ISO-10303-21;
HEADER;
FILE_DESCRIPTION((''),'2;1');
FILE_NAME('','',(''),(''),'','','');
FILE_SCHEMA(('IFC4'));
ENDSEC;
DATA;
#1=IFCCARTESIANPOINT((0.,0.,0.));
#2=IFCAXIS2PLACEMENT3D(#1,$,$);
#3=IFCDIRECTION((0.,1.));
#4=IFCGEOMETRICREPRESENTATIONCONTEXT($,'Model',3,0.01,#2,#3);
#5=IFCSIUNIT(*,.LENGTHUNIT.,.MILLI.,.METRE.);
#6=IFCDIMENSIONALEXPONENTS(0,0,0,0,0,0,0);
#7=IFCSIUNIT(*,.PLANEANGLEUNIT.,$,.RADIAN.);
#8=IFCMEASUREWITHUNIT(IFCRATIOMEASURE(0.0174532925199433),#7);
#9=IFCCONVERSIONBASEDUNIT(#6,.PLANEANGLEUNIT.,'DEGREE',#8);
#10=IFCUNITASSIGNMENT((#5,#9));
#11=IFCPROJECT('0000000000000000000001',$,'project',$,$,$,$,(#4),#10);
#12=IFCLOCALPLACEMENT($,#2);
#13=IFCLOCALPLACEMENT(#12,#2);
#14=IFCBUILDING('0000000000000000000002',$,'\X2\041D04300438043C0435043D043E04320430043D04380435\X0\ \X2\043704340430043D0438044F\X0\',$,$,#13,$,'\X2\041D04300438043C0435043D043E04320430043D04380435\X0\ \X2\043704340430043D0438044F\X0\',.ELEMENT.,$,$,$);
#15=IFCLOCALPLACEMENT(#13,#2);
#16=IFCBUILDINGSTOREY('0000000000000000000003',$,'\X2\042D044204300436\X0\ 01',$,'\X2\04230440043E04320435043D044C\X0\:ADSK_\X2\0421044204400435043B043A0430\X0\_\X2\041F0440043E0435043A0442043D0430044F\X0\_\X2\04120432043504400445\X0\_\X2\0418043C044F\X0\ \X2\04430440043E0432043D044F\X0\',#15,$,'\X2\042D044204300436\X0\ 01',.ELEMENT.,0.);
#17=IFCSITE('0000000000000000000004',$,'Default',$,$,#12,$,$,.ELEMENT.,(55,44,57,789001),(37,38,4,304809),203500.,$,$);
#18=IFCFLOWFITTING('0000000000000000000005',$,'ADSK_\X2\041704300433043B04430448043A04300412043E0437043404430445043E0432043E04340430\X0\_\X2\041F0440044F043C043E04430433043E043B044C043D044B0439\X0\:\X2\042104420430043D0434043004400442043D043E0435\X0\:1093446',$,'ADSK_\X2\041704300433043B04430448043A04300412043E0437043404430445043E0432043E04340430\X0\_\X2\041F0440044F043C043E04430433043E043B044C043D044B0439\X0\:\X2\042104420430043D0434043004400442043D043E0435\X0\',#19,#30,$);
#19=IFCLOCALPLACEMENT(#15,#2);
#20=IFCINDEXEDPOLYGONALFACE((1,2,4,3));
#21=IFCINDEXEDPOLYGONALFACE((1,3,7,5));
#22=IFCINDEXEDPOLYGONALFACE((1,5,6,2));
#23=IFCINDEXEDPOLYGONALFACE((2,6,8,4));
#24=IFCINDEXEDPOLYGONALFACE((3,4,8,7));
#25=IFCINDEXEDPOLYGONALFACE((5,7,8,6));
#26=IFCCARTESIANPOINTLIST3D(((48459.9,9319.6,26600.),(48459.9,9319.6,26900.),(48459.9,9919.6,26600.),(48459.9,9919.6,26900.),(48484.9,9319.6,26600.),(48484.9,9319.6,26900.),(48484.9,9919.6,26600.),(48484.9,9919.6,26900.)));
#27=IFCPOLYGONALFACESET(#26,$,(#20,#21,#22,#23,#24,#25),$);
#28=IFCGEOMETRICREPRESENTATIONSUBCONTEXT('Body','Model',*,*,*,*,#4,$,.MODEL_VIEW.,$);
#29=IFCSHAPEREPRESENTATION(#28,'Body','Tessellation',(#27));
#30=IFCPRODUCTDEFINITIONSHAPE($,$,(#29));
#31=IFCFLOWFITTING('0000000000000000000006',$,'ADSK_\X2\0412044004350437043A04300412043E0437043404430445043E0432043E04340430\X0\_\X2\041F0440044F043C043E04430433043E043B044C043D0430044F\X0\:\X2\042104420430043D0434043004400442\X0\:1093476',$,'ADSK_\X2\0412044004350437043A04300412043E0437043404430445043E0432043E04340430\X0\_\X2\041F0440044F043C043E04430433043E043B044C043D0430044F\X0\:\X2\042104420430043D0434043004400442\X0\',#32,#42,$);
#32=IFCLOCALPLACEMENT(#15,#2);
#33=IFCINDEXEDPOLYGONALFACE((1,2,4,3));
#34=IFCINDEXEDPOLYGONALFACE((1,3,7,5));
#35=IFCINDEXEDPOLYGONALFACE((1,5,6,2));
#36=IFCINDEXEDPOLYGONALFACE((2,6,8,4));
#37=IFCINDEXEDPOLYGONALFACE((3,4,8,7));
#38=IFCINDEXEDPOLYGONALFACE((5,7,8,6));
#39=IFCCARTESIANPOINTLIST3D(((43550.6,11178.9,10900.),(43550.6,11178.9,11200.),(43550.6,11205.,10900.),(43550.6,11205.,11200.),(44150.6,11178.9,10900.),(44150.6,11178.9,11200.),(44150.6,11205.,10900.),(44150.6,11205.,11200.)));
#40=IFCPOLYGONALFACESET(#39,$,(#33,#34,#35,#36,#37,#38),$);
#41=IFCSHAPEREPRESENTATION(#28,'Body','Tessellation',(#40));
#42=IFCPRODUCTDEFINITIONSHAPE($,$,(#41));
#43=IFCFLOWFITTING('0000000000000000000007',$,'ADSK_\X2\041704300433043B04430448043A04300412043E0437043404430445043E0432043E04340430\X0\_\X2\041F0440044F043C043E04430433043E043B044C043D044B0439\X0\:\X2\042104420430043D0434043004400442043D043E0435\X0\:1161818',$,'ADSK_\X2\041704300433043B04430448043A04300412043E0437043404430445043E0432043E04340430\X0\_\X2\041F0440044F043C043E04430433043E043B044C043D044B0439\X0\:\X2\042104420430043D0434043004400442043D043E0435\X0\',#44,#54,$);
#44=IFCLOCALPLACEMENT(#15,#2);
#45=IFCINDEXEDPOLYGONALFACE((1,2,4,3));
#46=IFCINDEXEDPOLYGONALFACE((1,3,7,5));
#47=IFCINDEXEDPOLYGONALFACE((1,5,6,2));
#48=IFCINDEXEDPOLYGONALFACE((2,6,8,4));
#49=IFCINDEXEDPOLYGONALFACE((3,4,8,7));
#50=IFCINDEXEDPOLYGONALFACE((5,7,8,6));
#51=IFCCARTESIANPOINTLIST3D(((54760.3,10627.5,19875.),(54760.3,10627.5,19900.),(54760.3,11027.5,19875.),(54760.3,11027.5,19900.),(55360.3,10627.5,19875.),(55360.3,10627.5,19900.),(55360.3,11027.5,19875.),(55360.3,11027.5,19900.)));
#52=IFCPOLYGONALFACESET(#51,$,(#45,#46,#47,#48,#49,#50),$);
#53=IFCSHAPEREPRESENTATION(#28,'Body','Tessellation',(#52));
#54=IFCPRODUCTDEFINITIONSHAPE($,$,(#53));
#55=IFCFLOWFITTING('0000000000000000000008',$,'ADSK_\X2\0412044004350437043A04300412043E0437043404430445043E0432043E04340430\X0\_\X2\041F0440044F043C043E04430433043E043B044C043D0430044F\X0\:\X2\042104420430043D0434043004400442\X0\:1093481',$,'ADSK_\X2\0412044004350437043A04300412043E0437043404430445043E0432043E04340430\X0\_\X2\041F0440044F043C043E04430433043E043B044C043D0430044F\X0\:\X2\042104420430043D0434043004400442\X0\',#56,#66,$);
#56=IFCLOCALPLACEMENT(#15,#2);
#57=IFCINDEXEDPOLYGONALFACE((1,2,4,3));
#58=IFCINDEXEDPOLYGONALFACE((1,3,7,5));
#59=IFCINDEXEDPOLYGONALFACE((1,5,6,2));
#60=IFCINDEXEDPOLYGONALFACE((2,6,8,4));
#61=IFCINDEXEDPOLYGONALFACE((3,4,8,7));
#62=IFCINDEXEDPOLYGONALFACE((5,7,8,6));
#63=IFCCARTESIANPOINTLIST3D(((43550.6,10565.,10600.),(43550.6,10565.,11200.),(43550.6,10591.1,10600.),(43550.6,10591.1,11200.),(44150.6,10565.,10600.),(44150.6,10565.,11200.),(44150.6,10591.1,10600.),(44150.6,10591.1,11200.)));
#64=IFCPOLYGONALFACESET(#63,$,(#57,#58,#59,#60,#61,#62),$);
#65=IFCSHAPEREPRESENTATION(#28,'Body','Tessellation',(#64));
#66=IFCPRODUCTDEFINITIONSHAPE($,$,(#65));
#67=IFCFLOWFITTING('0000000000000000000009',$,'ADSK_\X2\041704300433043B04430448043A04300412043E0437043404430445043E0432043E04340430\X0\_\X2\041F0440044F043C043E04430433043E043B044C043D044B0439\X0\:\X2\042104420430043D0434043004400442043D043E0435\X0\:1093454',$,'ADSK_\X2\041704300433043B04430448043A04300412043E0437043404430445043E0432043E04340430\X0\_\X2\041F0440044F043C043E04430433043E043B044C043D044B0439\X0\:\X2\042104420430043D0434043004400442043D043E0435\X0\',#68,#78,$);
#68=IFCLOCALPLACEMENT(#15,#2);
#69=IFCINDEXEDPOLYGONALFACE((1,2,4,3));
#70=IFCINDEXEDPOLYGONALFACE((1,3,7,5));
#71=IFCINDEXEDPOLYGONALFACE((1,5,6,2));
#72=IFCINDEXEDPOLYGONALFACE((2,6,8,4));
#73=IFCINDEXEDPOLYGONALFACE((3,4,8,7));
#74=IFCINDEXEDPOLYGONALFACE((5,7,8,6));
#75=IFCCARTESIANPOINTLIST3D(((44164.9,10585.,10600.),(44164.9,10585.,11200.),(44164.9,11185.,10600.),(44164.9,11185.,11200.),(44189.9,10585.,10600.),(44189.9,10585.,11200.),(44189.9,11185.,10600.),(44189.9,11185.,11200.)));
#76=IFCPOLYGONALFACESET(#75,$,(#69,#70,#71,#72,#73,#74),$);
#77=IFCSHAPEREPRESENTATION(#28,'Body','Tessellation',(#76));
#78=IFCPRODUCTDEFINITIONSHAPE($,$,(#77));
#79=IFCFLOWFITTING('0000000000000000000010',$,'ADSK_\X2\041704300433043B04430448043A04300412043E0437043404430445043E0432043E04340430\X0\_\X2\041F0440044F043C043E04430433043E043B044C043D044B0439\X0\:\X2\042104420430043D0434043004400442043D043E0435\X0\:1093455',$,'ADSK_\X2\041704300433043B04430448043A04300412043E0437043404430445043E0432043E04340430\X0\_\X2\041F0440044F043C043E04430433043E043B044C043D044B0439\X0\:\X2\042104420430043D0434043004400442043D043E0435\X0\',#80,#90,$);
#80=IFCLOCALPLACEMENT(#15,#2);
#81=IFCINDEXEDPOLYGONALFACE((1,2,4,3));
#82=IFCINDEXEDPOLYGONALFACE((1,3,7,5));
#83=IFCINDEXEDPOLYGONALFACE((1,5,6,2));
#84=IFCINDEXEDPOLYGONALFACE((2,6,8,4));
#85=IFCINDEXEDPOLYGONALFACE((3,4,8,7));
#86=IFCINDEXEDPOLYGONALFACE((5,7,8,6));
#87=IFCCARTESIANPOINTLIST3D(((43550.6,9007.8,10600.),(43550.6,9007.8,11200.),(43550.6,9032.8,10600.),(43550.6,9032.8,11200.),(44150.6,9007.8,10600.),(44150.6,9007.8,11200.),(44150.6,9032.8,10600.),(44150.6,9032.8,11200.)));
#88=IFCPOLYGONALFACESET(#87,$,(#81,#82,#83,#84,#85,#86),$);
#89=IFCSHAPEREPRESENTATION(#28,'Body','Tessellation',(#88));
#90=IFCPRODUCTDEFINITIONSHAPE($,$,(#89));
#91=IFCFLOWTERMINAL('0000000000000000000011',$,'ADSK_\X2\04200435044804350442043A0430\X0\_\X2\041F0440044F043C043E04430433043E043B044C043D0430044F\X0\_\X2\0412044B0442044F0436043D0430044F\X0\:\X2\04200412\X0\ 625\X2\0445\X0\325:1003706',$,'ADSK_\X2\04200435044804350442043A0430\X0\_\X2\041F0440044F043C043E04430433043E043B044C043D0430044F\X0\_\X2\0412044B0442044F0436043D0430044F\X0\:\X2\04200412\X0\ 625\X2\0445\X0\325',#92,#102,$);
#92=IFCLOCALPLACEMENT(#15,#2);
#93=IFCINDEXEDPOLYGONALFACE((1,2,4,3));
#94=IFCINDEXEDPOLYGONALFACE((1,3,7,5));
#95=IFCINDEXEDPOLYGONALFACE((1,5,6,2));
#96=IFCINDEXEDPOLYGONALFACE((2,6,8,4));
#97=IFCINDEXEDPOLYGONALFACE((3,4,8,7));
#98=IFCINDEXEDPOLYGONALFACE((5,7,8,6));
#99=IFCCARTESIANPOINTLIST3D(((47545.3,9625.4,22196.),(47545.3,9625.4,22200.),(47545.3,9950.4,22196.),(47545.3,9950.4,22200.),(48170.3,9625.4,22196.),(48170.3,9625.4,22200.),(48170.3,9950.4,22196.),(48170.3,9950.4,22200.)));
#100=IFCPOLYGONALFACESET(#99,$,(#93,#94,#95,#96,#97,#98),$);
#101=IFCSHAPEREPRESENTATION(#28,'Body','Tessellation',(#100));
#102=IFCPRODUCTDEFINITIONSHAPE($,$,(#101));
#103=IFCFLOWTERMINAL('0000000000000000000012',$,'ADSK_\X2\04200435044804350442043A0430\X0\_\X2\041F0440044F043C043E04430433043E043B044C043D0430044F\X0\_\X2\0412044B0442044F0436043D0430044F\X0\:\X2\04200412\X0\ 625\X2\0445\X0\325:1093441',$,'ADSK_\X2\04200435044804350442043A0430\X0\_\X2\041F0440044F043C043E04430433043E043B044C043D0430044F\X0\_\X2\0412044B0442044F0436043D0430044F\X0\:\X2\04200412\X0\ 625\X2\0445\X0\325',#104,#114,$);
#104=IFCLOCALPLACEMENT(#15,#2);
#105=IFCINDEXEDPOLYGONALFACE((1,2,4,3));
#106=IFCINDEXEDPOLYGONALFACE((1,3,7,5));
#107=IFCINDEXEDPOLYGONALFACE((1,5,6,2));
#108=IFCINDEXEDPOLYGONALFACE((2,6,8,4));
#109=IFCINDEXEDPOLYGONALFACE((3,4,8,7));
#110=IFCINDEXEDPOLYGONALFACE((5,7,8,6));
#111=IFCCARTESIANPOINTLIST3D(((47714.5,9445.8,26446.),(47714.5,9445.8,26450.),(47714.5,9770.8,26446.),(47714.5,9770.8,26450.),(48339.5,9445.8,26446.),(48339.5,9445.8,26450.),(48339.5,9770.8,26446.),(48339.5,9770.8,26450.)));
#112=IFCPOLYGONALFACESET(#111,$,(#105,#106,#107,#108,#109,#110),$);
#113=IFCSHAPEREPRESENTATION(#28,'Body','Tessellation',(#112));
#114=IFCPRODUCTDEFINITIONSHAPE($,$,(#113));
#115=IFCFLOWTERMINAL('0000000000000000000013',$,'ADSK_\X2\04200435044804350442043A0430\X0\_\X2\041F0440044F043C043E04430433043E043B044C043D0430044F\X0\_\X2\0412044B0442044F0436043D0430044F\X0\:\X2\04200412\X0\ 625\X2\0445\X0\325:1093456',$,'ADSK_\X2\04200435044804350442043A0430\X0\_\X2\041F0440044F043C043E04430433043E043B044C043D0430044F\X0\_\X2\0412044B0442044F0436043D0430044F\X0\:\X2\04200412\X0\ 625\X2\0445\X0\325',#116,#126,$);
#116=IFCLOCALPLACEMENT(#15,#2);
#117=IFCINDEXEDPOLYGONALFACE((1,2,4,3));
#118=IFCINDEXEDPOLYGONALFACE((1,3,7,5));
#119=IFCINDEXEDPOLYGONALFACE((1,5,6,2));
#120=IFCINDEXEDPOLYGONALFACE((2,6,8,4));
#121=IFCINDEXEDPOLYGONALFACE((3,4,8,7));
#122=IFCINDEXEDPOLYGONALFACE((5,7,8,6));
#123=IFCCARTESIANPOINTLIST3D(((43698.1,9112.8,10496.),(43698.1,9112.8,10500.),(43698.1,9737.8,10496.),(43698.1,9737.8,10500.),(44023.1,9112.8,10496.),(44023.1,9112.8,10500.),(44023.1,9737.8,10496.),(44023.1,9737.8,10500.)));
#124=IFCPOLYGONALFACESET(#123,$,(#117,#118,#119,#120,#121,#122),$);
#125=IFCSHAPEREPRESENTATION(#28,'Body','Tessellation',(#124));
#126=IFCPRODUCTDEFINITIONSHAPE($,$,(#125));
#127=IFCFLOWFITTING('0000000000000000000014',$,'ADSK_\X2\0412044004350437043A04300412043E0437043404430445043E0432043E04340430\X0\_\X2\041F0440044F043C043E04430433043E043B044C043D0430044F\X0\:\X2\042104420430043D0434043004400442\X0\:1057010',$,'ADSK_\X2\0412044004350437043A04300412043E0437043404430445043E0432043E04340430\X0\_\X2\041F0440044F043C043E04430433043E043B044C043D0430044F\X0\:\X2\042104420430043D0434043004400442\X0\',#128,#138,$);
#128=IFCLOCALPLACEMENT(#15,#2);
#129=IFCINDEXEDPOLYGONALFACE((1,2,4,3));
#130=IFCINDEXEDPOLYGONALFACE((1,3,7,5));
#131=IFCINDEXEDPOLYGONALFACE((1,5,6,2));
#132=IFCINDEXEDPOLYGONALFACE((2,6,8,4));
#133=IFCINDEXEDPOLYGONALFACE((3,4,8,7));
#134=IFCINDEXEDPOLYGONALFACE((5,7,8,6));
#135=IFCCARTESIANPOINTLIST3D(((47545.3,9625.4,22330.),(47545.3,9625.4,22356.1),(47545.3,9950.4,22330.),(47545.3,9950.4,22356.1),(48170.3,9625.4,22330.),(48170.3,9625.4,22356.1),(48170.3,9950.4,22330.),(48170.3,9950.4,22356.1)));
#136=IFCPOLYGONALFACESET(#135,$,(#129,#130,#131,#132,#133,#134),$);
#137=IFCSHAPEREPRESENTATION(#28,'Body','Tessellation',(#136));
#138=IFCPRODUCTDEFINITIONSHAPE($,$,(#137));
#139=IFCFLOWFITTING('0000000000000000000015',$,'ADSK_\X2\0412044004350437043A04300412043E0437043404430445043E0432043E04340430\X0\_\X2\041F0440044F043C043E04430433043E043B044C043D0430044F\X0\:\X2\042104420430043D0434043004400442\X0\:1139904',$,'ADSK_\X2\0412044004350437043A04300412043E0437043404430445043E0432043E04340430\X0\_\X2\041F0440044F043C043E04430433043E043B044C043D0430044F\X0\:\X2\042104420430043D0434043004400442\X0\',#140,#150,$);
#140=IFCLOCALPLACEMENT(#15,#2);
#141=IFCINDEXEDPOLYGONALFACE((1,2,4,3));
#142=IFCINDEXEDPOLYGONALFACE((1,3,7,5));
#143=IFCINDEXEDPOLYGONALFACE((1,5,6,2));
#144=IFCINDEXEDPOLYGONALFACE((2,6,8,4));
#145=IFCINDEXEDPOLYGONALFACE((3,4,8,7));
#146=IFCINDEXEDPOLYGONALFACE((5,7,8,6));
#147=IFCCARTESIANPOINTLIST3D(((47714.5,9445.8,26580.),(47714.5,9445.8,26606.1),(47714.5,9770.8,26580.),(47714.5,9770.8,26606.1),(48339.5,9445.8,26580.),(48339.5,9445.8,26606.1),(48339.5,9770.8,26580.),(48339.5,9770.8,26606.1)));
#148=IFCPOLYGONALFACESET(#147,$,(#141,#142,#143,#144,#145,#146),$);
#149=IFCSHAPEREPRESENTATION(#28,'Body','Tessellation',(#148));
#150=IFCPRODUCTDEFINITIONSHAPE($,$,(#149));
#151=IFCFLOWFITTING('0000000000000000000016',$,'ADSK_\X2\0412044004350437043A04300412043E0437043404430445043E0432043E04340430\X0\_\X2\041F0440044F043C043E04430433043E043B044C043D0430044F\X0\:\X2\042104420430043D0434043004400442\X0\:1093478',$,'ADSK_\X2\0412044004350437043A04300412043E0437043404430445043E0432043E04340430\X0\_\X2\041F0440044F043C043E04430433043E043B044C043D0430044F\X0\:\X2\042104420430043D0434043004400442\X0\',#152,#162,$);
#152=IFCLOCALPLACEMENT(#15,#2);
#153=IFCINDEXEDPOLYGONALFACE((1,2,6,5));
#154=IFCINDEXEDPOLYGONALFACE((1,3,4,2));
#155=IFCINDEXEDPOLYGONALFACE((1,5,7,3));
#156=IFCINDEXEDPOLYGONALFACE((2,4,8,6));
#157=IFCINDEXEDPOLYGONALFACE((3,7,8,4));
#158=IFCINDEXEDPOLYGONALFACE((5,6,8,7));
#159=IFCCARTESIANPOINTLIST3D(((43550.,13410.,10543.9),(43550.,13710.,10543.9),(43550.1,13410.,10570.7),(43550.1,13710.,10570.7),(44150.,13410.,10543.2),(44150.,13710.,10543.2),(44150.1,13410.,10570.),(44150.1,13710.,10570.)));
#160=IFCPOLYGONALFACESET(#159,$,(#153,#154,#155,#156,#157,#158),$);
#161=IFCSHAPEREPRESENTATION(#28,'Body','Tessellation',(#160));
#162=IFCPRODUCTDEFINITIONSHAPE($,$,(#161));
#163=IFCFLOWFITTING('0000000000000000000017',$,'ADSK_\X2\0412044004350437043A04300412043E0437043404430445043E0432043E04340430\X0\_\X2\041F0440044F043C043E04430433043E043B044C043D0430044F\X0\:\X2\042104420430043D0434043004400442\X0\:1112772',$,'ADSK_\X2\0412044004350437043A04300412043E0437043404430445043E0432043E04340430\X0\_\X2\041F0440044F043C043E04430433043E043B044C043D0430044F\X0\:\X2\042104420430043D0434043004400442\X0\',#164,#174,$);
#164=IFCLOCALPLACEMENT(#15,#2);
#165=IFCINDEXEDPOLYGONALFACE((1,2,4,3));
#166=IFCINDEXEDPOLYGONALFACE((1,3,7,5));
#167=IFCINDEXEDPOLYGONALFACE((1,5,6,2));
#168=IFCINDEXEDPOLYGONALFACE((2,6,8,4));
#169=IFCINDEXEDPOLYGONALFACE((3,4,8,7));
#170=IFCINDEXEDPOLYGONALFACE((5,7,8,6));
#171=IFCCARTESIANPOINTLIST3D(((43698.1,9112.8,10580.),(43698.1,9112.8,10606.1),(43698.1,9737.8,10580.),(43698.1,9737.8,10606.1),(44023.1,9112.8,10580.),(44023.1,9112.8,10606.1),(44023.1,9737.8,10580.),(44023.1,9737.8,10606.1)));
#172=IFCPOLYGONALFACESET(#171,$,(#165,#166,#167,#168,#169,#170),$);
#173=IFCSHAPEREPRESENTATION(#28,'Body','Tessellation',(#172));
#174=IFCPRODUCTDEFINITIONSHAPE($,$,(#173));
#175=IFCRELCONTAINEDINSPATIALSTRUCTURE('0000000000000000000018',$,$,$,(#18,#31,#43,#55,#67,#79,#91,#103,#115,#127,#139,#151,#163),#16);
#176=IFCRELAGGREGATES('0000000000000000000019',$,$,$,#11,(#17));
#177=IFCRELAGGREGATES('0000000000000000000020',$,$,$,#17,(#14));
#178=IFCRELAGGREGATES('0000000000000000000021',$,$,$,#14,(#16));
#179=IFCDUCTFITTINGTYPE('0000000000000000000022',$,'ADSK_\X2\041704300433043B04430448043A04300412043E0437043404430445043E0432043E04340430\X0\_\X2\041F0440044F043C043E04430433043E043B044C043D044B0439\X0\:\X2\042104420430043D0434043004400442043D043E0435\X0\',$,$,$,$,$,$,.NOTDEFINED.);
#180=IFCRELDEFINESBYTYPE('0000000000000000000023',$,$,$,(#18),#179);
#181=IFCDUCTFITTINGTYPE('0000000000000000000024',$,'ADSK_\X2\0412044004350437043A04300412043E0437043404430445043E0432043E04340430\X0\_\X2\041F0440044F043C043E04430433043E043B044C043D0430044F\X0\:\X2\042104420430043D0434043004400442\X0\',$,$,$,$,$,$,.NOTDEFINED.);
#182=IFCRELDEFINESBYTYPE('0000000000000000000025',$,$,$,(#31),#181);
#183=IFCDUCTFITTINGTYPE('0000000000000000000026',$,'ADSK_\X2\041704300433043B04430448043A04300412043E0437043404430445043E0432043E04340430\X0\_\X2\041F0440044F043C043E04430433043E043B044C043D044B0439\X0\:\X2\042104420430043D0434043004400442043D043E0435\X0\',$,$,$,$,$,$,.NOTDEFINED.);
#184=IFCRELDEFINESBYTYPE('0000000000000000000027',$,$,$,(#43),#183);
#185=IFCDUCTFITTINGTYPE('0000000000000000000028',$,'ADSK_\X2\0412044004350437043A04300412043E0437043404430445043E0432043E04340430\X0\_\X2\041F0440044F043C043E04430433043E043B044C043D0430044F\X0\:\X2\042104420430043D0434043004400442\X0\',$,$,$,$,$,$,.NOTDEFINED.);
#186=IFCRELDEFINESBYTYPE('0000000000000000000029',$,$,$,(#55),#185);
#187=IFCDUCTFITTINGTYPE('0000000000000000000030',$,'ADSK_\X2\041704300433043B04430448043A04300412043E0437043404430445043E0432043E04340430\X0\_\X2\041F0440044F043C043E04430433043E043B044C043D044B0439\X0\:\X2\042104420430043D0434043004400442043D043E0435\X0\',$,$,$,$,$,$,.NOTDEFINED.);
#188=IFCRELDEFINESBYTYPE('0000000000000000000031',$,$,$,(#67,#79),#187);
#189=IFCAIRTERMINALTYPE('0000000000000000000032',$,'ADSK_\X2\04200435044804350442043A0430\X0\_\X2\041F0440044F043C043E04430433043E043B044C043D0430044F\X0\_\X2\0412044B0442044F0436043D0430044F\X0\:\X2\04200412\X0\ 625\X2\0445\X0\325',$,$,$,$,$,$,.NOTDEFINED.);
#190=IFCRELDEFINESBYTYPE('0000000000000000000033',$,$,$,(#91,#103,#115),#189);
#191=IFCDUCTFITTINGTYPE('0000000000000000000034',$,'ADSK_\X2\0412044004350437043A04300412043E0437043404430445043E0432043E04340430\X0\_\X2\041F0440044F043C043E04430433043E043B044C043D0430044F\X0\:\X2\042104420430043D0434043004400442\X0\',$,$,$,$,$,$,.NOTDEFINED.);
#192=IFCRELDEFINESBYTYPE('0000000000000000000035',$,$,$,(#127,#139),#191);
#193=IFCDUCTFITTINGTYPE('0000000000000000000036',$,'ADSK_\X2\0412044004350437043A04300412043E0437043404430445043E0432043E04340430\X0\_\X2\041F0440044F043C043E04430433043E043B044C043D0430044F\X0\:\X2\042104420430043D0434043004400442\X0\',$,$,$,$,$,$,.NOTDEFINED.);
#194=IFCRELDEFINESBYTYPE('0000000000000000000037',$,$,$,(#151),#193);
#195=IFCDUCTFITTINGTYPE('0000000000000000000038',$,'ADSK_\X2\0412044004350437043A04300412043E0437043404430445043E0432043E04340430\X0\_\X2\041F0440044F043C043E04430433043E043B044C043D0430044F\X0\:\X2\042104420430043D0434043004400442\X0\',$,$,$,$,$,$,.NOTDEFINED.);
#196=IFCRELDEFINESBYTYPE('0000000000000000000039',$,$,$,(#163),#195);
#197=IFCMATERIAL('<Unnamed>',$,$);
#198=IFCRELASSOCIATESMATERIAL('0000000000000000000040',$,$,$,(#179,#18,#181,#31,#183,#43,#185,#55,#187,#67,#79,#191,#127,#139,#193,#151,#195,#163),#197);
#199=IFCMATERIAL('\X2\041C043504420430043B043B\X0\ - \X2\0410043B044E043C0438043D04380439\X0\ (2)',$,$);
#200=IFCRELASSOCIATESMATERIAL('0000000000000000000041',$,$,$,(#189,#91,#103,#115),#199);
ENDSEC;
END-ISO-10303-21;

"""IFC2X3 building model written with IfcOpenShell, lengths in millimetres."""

from ifc_helpers import new_model, entity, si_unit, converted_unit, direction, frame, origin, origin_2d_with_axis, place, context, subcontext, project, spatial, rectangle, extrude, source, transform, mapped, material, type_object, type_shapes, element, save


model = new_model("IFC2X3")

# Units and contexts
model_context = context("Model", 3, precision=0.01, world=origin(), true_north=direction((0.0, 1.0)))
body_context = subcontext(model_context, "Body", "Model", "MODEL_VIEW")
ifc_project = project(units=[si_unit("LENGTHUNIT", "METRE", prefix="MILLI"), converted_unit("PLANEANGLEUNIT", "DEGREE", entity("IfcRatioMeasure", 0.0174532925199433), si_unit("PLANEANGLEUNIT", "RADIAN"), dimensions=[0, 0, 0, 0, 0, 0, 0])], contexts=[model_context])

# Site, building, storey
site_placement = place(None, origin())
site = spatial("IfcSite", under=ifc_project, at=site_placement, Name="Default", CompositionType="ELEMENT", RefLatitude=(55, 44, 57, 789001), RefLongitude=(37, 38, 4, 304809), RefElevation=203500.0)
building_placement = place(site_placement, origin())
building = spatial("IfcBuilding", under=site, at=building_placement, Name="Наименование здания", LongName="Наименование здания", CompositionType="ELEMENT")
storey_placement = place(building_placement, origin())
storey = spatial("IfcBuildingStorey", under=building, at=storey_placement, Name="Этаж 01", ObjectType="Уровень:ADSK_Стрелка_Проектная_Вверх_Имя уровня", LongName="Этаж 01", CompositionType="ELEMENT", Elevation=0.0)

# Flow fittings
ifc_material_1 = material(Name="<Unnamed>")
duct_fitting_type_1 = type_object("IfcDuctFittingType", Name="ADSK_ЗаглушкаВоздуховода_Прямоугольный:Стандартное", PredefinedType="NOTDEFINED", material=ifc_material_1)
shared_shape_1 = source(origin(), body_context, "Body", "SweptSolid", [
    extrude(rectangle(XDim=25.0, YDim=600.0, at=origin_2d_with_axis()), frame((12.5, 0.0, -150.0)), (0.0, 0.0, 1.0), 300.0),
])
type_shapes(duct_fitting_type_1, [shared_shape_1])
flow_fitting_1_placement = place(storey_placement, frame((48459.9, 9619.6, 26750.0)))
element("IfcFlowFitting", 1, at=flow_fitting_1_placement, inside=storey, type_object=duct_fitting_type_1, material=ifc_material_1, Name="ADSK_ЗаглушкаВоздуховода_Прямоугольный:Стандартное:1093446", ObjectType="ADSK_ЗаглушкаВоздуховода_Прямоугольный:Стандартное", context=body_context, shape_type="MappedRepresentation", body=[
    mapped(shared_shape_1, transform((0.0, 0.0, 0.0), scale=1.0)),
])
duct_fitting_type_2 = type_object("IfcDuctFittingType", Name="ADSK_ВрезкаВоздуховода_Прямоугольная:Стандарт", PredefinedType="NOTDEFINED", material=ifc_material_1)
shared_shape_2 = source(origin(), body_context, "Body", "SweptSolid", [
    extrude(rectangle(XDim=600.0, YDim=26.1, at=origin_2d_with_axis()), frame((7.0, 0.0, -150.0), z_axis=(0.0, 0.0, 1.0), x_axis=(0.0, -1.0, 0.0)), (0.0, 0.0, 1.0), 300.0),
])
type_shapes(duct_fitting_type_2, [shared_shape_2])
flow_fitting_2_placement = place(storey_placement, frame((43850.6, 11185.0, 11050.0), z_axis=(0.0, 0.0, -1.0), x_axis=(0.0, 1.0, 0.0)))
element("IfcFlowFitting", 2, at=flow_fitting_2_placement, inside=storey, type_object=duct_fitting_type_2, material=ifc_material_1, Name="ADSK_ВрезкаВоздуховода_Прямоугольная:Стандарт:1093476", ObjectType="ADSK_ВрезкаВоздуховода_Прямоугольная:Стандарт", context=body_context, shape_type="MappedRepresentation", body=[
    mapped(shared_shape_2, transform((0.0, 0.0, 0.0), scale=1.0)),
])
duct_fitting_type_3 = type_object("IfcDuctFittingType", Name="ADSK_ЗаглушкаВоздуховода_Прямоугольный:Стандартное", PredefinedType="NOTDEFINED", material=ifc_material_1)
shared_shape_3 = source(origin(), body_context, "Body", "SweptSolid", [
    extrude(rectangle(XDim=25.0, YDim=600.0, at=origin_2d_with_axis()), frame((12.5, 0.0, -200.0)), (0.0, 0.0, 1.0), 400.0),
])
type_shapes(duct_fitting_type_3, [shared_shape_3])
flow_fitting_3_placement = place(storey_placement, frame((55060.3, 10827.5, 19900.0), z_axis=(0.0, 1.0, 0.0), x_axis=(0.0, 0.0, -1.0)))
element("IfcFlowFitting", 3, at=flow_fitting_3_placement, inside=storey, type_object=duct_fitting_type_3, material=ifc_material_1, Name="ADSK_ЗаглушкаВоздуховода_Прямоугольный:Стандартное:1161818", ObjectType="ADSK_ЗаглушкаВоздуховода_Прямоугольный:Стандартное", context=body_context, shape_type="MappedRepresentation", body=[
    mapped(shared_shape_3, transform((0.0, 0.0, 0.0), scale=1.0)),
])
duct_fitting_type_4 = type_object("IfcDuctFittingType", Name="ADSK_ВрезкаВоздуховода_Прямоугольная:Стандарт", PredefinedType="NOTDEFINED", material=ifc_material_1)
shared_shape_4 = source(origin(), body_context, "Body", "SweptSolid", [
    extrude(rectangle(XDim=26.1, YDim=600.0, at=origin_2d_with_axis()), frame((7.0, 0.0, -300.0)), (0.0, 0.0, 1.0), 600.0),
])
type_shapes(duct_fitting_type_4, [shared_shape_4])
flow_fitting_4_placement = place(storey_placement, frame((43850.6, 10585.0, 10900.0), z_axis=(0.0, 0.0, -1.0), x_axis=(0.0, -1.0, 0.0)))
element("IfcFlowFitting", 4, at=flow_fitting_4_placement, inside=storey, type_object=duct_fitting_type_4, material=ifc_material_1, Name="ADSK_ВрезкаВоздуховода_Прямоугольная:Стандарт:1093481", ObjectType="ADSK_ВрезкаВоздуховода_Прямоугольная:Стандарт", context=body_context, shape_type="MappedRepresentation", body=[
    mapped(shared_shape_4, transform((0.0, 0.0, 0.0), scale=1.0)),
])
duct_fitting_type_5 = type_object("IfcDuctFittingType", Name="ADSK_ЗаглушкаВоздуховода_Прямоугольный:Стандартное", PredefinedType="NOTDEFINED", material=ifc_material_1)
shared_shape_5 = source(origin(), body_context, "Body", "SweptSolid", [
    extrude(rectangle(XDim=25.0, YDim=600.0, at=origin_2d_with_axis()), frame((12.5, 0.0, -300.0)), (0.0, 0.0, 1.0), 600.0),
])
type_shapes(duct_fitting_type_5, [shared_shape_5])
flow_fitting_5_placement = place(storey_placement, frame((44164.9, 10885.0, 10900.0)))
element("IfcFlowFitting", 5, at=flow_fitting_5_placement, inside=storey, type_object=duct_fitting_type_5, material=ifc_material_1, Name="ADSK_ЗаглушкаВоздуховода_Прямоугольный:Стандартное:1093454", ObjectType="ADSK_ЗаглушкаВоздуховода_Прямоугольный:Стандартное", context=body_context, shape_type="MappedRepresentation", body=[
    mapped(shared_shape_5, transform((0.0, 0.0, 0.0), scale=1.0)),
])
flow_fitting_6_placement = place(storey_placement, frame((43850.6, 9032.8, 10900.0), z_axis=(0.0, 0.0, 1.0), x_axis=(0.0, -1.0, 0.0)))
element("IfcFlowFitting", 6, at=flow_fitting_6_placement, inside=storey, type_object=duct_fitting_type_5, material=ifc_material_1, Name="ADSK_ЗаглушкаВоздуховода_Прямоугольный:Стандартное:1093455", ObjectType="ADSK_ЗаглушкаВоздуховода_Прямоугольный:Стандартное", context=body_context, shape_type="MappedRepresentation", body=[
    mapped(shared_shape_5, transform((0.0, 0.0, 0.0), scale=1.0)),
])

# Flow terminals
ifc_material_2 = material(Name="Металл - Алюминий (2)")
air_terminal_type = type_object("IfcAirTerminalType", Name="ADSK_Решетка_Прямоугольная_Вытяжная:РВ 625х325", PredefinedType="NOTDEFINED", material=ifc_material_2)
shared_shape_6 = source(origin(), body_context, "Body", "SweptSolid", [
    extrude(rectangle(XDim=4.0, YDim=625.0, at=origin_2d_with_axis()), frame((0.0, -2.0, -162.5), z_axis=(0.0, 0.0, 1.0), x_axis=(0.0, 1.0, 0.0)), (0.0, 0.0, 1.0), 325.0),
])
type_shapes(air_terminal_type, [shared_shape_6])
for number, where, z_axis, x_axis, name in (
    (7, (47857.8, 9788.0, 22200.0), (0.0, -1.0, 0.0), (1.0, 0.0, 0.0), "ADSK_Решетка_Прямоугольная_Вытяжная:РВ 625х325:1003706"),
    (8, (48027.0, 9608.3, 26450.0), (0.0, 1.0, 0.0), (-1.0, 0.0, 0.0), "ADSK_Решетка_Прямоугольная_Вытяжная:РВ 625х325:1093441"),
    (9, (43860.6, 9425.3, 10500.0), (1.0, 0.0, 0.0), (0.0, 1.0, 0.0), "ADSK_Решетка_Прямоугольная_Вытяжная:РВ 625х325:1093456"),
):
    element("IfcFlowTerminal", number, at=place(storey_placement, frame(where, z_axis=z_axis, x_axis=x_axis)), inside=storey, type_object=air_terminal_type, material=ifc_material_2, Name=name, ObjectType="ADSK_Решетка_Прямоугольная_Вытяжная:РВ 625х325", context=body_context, shape_type="MappedRepresentation", body=[
        mapped(shared_shape_6, transform((0.0, 0.0, 0.0), scale=1.0)),
    ])

# Flow fittings
duct_fitting_type_6 = type_object("IfcDuctFittingType", Name="ADSK_ВрезкаВоздуховода_Прямоугольная:Стандарт", PredefinedType="NOTDEFINED", material=ifc_material_1)
shared_shape_7 = source(origin(), body_context, "Body", "SweptSolid", [
    extrude(rectangle(XDim=26.1, YDim=625.0, at=origin_2d_with_axis()), frame((7.0, 0.0, -162.5)), (0.0, 0.0, 1.0), 325.0),
])
type_shapes(duct_fitting_type_6, [shared_shape_7])
for number, where, z_axis, x_axis, name in (
    (10, (47857.8, 9788.0, 22350.0), (0.0, -1.0, 0.0), (0.0, 0.0, -1.0), "ADSK_ВрезкаВоздуховода_Прямоугольная:Стандарт:1057010"),
    (11, (48027.0, 9608.3, 26600.0), (0.0, 1.0, 0.0), (0.0, 0.0, -1.0), "ADSK_ВрезкаВоздуховода_Прямоугольная:Стандарт:1139904"),
):
    element("IfcFlowFitting", number, at=place(storey_placement, frame(where, z_axis=z_axis, x_axis=x_axis)), inside=storey, type_object=duct_fitting_type_6, material=ifc_material_1, Name=name, ObjectType="ADSK_ВрезкаВоздуховода_Прямоугольная:Стандарт", context=body_context, shape_type="MappedRepresentation", body=[
        mapped(shared_shape_7, transform((0.0, 0.0, 0.0), scale=1.0)),
    ])
duct_fitting_type_7 = type_object("IfcDuctFittingType", Name="ADSK_ВрезкаВоздуховода_Прямоугольная:Стандарт", PredefinedType="NOTDEFINED", material=ifc_material_1)
shared_shape_8 = source(origin(), body_context, "Body", "SweptSolid", [
    extrude(rectangle(XDim=600.0, YDim=26.8, at=origin_2d_with_axis()), frame((7.0, 0.0, -150.0), z_axis=(0.0, 0.0, 1.0), x_axis=(0.0, -1.0, 0.0)), (0.0, 0.0, 1.0), 300.0),
])
type_shapes(duct_fitting_type_7, [shared_shape_8])
flow_fitting_7_placement = place(storey_placement, frame((43850.1, 13560.0, 10550.0), z_axis=(0.0, 1.0, 0.0), x_axis=(0.0011, 0.0, 0.999999)))
element("IfcFlowFitting", 12, at=flow_fitting_7_placement, inside=storey, type_object=duct_fitting_type_7, material=ifc_material_1, Name="ADSK_ВрезкаВоздуховода_Прямоугольная:Стандарт:1093478", ObjectType="ADSK_ВрезкаВоздуховода_Прямоугольная:Стандарт", context=body_context, shape_type="MappedRepresentation", body=[
    mapped(shared_shape_8, transform((0.0, 0.0, 0.0), scale=1.0)),
])
duct_fitting_type_8 = type_object("IfcDuctFittingType", Name="ADSK_ВрезкаВоздуховода_Прямоугольная:Стандарт", PredefinedType="NOTDEFINED", material=ifc_material_1)
shared_shape_9 = source(origin(), body_context, "Body", "SweptSolid", [
    extrude(rectangle(XDim=325.0, YDim=26.1, at=origin_2d_with_axis()), frame((7.0, 0.0, -312.5), z_axis=(0.0, 0.0, 1.0), x_axis=(0.0, -1.0, 0.0)), (0.0, 0.0, 1.0), 625.0),
])
type_shapes(duct_fitting_type_8, [shared_shape_9])
flow_fitting_8_placement = place(storey_placement, frame((43860.6, 9425.3, 10600.0), z_axis=(0.0, -1.0, 0.0), x_axis=(0.0, 0.0, -1.0)))
element("IfcFlowFitting", 13, at=flow_fitting_8_placement, inside=storey, type_object=duct_fitting_type_8, material=ifc_material_1, Name="ADSK_ВрезкаВоздуховода_Прямоугольная:Стандарт:1112772", ObjectType="ADSK_ВрезкаВоздуховода_Прямоугольная:Стандарт", context=body_context, shape_type="MappedRepresentation", body=[
    mapped(shared_shape_9, transform((0.0, 0.0, 0.0), scale=1.0)),
])

save(model, "model.ifc")
